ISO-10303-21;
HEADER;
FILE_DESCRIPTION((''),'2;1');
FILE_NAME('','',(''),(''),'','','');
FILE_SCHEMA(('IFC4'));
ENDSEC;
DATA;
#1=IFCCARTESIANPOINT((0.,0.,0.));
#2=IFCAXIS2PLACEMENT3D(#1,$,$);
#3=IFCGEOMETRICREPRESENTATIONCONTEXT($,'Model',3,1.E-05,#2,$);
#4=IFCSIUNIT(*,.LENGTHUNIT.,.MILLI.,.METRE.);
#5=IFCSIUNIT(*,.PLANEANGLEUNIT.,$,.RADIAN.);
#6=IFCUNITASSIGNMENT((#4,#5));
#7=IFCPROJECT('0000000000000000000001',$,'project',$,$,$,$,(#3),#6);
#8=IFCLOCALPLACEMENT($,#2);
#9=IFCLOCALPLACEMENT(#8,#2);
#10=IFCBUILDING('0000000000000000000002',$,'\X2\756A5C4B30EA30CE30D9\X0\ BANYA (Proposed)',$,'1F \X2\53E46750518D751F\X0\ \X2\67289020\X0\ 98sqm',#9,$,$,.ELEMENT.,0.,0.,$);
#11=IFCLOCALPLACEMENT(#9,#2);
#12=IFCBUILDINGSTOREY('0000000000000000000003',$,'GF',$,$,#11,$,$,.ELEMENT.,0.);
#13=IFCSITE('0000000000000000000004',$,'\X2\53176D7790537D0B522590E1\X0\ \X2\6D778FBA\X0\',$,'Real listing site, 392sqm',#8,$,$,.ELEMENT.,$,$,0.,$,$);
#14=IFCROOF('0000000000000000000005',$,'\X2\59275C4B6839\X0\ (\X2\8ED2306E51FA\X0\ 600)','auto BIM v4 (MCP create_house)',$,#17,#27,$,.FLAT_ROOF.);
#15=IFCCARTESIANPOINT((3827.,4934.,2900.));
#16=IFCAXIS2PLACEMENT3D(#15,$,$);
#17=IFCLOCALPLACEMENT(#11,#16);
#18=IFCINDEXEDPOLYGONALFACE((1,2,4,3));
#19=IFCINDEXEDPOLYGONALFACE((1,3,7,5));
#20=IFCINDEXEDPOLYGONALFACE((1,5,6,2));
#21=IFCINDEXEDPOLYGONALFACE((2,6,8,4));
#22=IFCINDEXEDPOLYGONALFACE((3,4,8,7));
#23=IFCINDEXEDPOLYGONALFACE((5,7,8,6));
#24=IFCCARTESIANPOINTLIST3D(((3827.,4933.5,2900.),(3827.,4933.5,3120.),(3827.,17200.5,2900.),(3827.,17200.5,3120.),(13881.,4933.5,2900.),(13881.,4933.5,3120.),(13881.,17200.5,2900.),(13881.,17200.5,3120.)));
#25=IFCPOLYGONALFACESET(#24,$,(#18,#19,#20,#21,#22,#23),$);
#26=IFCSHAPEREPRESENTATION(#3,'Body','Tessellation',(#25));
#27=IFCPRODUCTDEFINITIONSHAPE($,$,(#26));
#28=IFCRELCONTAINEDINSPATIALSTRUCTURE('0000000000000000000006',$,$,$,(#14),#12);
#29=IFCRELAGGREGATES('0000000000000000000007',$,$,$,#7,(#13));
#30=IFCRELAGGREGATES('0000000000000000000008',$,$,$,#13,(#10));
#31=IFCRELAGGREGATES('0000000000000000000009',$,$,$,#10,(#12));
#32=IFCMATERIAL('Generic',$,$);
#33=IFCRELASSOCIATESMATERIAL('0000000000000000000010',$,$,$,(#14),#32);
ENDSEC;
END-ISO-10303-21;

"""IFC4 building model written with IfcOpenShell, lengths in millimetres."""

from ifc_helpers import new_model, si_unit, frame, frame_2d, origin, place, context, project, spatial, rectangle, extrude, material, element, save


model = new_model("IFC4")

# Units and contexts
model_context = context("Model", 3, precision=1e-05, world=origin())
ifc_project = project(units=[si_unit("LENGTHUNIT", "METRE", prefix="MILLI"), si_unit("PLANEANGLEUNIT", "RADIAN")], contexts=[model_context])

# Site, building, storey
site_placement = place(None, origin())
site = spatial("IfcSite", under=ifc_project, at=site_placement, Name="北海道紋別郡 海辺", ObjectType="Real listing site, 392sqm", CompositionType="ELEMENT", RefElevation=0.0)
building_placement = place(site_placement, origin())
building = spatial("IfcBuilding", under=site, at=building_placement, Name="番屋リノベ BANYA (Proposed)", ObjectType="1F 古材再生 木造 98sqm", CompositionType="ELEMENT", ElevationOfRefHeight=0.0, ElevationOfTerrain=0.0)
storey_placement = place(building_placement, origin())
storey = spatial("IfcBuildingStorey", under=building, at=storey_placement, Name="GF", CompositionType="ELEMENT", Elevation=0.0)

# Shared definitions
ifc_material = material(Name="Generic")

# Roof
roof_placement = place(storey_placement, frame((3827.0, 4934.0, 2900.0)))
element("IfcRoof", 1, at=roof_placement, inside=storey, material=ifc_material, Name="大屋根 (軒の出 600)", Description="auto BIM v4 (MCP create_house)", PredefinedType="FLAT_ROOF", context=model_context, shape_type="SweptSolid", body=[
    extrude(rectangle(XDim=10054.0, YDim=12267.0, at=frame_2d((5027.0, 6133.0))), frame((3827.0, 4934.0, 2900.0)), (0.0, 0.0, 1.0), 220.0),
])

save(model, "model.ifc")
